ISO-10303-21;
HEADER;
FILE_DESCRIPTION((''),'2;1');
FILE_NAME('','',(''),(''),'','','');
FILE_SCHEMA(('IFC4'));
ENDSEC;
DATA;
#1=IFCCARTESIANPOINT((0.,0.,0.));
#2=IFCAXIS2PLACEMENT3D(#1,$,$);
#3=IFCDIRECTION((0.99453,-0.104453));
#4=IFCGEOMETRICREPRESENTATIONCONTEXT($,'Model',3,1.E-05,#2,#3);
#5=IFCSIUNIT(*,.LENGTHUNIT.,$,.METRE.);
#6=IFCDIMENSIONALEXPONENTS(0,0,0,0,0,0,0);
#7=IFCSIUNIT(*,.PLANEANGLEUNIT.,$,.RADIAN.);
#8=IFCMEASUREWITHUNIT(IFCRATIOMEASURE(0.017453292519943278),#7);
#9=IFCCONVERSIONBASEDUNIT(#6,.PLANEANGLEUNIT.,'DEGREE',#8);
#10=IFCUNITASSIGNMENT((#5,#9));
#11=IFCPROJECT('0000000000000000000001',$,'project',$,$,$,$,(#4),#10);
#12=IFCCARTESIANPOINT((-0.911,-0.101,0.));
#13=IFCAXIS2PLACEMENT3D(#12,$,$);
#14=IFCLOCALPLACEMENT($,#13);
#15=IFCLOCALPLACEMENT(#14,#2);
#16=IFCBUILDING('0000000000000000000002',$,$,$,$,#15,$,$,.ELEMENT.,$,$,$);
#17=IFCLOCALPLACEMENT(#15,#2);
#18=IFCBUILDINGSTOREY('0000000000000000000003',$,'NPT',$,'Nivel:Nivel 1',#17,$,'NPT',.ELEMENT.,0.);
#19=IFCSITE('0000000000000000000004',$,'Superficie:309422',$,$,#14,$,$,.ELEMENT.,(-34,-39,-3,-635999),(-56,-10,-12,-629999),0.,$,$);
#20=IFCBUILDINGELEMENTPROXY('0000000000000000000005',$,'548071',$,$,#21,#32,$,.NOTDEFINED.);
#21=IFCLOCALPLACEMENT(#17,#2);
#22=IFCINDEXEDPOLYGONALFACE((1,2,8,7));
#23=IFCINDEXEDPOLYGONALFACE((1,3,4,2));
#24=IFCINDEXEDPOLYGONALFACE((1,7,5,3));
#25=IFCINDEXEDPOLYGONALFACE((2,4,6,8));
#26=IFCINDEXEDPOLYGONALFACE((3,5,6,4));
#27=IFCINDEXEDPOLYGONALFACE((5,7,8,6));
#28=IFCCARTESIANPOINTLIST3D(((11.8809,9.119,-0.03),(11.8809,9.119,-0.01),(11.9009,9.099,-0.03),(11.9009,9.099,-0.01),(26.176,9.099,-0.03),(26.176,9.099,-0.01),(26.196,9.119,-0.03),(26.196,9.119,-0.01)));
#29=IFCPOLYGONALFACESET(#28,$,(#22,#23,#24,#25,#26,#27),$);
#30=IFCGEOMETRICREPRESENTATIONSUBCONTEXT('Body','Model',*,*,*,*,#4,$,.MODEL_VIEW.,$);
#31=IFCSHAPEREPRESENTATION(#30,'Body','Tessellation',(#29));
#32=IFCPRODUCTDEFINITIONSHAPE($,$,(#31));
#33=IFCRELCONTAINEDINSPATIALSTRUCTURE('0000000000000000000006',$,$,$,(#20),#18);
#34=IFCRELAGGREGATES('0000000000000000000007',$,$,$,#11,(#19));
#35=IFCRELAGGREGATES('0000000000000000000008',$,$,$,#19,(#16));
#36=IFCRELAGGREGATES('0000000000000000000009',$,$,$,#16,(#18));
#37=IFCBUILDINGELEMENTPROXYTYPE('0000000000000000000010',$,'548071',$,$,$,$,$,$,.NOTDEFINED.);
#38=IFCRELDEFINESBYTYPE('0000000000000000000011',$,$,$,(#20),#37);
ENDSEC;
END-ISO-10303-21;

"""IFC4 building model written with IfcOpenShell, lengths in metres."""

from ifc_helpers import new_model, entity, si_unit, converted_unit, direction, frame, origin, place, context, subcontext, project, spatial, polyline, outline, extrude, type_object, element, save


model = new_model("IFC4")

# Units and contexts
model_context = context("Model", 3, precision=1e-05, world=origin(), true_north=direction((0.99453, -0.104453)))
body_context = subcontext(model_context, "Body", "Model", "MODEL_VIEW")
ifc_project = project(units=[si_unit("LENGTHUNIT", "METRE"), converted_unit("PLANEANGLEUNIT", "DEGREE", entity("IfcRatioMeasure", 0.017453292519943278), si_unit("PLANEANGLEUNIT", "RADIAN"), dimensions=[0, 0, 0, 0, 0, 0, 0])], contexts=[model_context])

# Site, building, storey
site_placement = place(None, frame((-0.911, -0.101, 0.0)))
site = spatial("IfcSite", under=ifc_project, at=site_placement, Name="Superficie:309422", CompositionType="ELEMENT", RefLatitude=(-34, -39, -3, -635999), RefLongitude=(-56, -10, -12, -629999), RefElevation=0.0)
building_placement = place(site_placement, origin())
building = spatial("IfcBuilding", under=site, at=building_placement, CompositionType="ELEMENT")
storey_placement = place(building_placement, origin())
storey = spatial("IfcBuildingStorey", under=building, at=storey_placement, Name="NPT", ObjectType="Nivel:Nivel 1", LongName="NPT", CompositionType="ELEMENT", Elevation=0.0)

# Building element proxy
building_element_proxy_type_1 = type_object("IfcBuildingElementProxyType", Name="548071", PredefinedType="NOTDEFINED")
proxy_1_placement = place(storey_placement, frame((11.8809, 9.099, -0.03)))
element("IfcBuildingElementProxy", 1, at=proxy_1_placement, inside=storey, type_object=building_element_proxy_type_1, Name="548071", PredefinedType="NOTDEFINED", context=body_context, shape_type="SweptSolid", body=[
    extrude(outline(polyline([(-7.1375, -0.01), (7.1375, -0.01), (7.1575, 0.01), (-7.1575, 0.01), (-7.1375, -0.01)])), frame((7.1575, 0.01, 0.0)), (0.0, 0.0, 1.0), 0.02),
])

save(model, "model.ifc")
